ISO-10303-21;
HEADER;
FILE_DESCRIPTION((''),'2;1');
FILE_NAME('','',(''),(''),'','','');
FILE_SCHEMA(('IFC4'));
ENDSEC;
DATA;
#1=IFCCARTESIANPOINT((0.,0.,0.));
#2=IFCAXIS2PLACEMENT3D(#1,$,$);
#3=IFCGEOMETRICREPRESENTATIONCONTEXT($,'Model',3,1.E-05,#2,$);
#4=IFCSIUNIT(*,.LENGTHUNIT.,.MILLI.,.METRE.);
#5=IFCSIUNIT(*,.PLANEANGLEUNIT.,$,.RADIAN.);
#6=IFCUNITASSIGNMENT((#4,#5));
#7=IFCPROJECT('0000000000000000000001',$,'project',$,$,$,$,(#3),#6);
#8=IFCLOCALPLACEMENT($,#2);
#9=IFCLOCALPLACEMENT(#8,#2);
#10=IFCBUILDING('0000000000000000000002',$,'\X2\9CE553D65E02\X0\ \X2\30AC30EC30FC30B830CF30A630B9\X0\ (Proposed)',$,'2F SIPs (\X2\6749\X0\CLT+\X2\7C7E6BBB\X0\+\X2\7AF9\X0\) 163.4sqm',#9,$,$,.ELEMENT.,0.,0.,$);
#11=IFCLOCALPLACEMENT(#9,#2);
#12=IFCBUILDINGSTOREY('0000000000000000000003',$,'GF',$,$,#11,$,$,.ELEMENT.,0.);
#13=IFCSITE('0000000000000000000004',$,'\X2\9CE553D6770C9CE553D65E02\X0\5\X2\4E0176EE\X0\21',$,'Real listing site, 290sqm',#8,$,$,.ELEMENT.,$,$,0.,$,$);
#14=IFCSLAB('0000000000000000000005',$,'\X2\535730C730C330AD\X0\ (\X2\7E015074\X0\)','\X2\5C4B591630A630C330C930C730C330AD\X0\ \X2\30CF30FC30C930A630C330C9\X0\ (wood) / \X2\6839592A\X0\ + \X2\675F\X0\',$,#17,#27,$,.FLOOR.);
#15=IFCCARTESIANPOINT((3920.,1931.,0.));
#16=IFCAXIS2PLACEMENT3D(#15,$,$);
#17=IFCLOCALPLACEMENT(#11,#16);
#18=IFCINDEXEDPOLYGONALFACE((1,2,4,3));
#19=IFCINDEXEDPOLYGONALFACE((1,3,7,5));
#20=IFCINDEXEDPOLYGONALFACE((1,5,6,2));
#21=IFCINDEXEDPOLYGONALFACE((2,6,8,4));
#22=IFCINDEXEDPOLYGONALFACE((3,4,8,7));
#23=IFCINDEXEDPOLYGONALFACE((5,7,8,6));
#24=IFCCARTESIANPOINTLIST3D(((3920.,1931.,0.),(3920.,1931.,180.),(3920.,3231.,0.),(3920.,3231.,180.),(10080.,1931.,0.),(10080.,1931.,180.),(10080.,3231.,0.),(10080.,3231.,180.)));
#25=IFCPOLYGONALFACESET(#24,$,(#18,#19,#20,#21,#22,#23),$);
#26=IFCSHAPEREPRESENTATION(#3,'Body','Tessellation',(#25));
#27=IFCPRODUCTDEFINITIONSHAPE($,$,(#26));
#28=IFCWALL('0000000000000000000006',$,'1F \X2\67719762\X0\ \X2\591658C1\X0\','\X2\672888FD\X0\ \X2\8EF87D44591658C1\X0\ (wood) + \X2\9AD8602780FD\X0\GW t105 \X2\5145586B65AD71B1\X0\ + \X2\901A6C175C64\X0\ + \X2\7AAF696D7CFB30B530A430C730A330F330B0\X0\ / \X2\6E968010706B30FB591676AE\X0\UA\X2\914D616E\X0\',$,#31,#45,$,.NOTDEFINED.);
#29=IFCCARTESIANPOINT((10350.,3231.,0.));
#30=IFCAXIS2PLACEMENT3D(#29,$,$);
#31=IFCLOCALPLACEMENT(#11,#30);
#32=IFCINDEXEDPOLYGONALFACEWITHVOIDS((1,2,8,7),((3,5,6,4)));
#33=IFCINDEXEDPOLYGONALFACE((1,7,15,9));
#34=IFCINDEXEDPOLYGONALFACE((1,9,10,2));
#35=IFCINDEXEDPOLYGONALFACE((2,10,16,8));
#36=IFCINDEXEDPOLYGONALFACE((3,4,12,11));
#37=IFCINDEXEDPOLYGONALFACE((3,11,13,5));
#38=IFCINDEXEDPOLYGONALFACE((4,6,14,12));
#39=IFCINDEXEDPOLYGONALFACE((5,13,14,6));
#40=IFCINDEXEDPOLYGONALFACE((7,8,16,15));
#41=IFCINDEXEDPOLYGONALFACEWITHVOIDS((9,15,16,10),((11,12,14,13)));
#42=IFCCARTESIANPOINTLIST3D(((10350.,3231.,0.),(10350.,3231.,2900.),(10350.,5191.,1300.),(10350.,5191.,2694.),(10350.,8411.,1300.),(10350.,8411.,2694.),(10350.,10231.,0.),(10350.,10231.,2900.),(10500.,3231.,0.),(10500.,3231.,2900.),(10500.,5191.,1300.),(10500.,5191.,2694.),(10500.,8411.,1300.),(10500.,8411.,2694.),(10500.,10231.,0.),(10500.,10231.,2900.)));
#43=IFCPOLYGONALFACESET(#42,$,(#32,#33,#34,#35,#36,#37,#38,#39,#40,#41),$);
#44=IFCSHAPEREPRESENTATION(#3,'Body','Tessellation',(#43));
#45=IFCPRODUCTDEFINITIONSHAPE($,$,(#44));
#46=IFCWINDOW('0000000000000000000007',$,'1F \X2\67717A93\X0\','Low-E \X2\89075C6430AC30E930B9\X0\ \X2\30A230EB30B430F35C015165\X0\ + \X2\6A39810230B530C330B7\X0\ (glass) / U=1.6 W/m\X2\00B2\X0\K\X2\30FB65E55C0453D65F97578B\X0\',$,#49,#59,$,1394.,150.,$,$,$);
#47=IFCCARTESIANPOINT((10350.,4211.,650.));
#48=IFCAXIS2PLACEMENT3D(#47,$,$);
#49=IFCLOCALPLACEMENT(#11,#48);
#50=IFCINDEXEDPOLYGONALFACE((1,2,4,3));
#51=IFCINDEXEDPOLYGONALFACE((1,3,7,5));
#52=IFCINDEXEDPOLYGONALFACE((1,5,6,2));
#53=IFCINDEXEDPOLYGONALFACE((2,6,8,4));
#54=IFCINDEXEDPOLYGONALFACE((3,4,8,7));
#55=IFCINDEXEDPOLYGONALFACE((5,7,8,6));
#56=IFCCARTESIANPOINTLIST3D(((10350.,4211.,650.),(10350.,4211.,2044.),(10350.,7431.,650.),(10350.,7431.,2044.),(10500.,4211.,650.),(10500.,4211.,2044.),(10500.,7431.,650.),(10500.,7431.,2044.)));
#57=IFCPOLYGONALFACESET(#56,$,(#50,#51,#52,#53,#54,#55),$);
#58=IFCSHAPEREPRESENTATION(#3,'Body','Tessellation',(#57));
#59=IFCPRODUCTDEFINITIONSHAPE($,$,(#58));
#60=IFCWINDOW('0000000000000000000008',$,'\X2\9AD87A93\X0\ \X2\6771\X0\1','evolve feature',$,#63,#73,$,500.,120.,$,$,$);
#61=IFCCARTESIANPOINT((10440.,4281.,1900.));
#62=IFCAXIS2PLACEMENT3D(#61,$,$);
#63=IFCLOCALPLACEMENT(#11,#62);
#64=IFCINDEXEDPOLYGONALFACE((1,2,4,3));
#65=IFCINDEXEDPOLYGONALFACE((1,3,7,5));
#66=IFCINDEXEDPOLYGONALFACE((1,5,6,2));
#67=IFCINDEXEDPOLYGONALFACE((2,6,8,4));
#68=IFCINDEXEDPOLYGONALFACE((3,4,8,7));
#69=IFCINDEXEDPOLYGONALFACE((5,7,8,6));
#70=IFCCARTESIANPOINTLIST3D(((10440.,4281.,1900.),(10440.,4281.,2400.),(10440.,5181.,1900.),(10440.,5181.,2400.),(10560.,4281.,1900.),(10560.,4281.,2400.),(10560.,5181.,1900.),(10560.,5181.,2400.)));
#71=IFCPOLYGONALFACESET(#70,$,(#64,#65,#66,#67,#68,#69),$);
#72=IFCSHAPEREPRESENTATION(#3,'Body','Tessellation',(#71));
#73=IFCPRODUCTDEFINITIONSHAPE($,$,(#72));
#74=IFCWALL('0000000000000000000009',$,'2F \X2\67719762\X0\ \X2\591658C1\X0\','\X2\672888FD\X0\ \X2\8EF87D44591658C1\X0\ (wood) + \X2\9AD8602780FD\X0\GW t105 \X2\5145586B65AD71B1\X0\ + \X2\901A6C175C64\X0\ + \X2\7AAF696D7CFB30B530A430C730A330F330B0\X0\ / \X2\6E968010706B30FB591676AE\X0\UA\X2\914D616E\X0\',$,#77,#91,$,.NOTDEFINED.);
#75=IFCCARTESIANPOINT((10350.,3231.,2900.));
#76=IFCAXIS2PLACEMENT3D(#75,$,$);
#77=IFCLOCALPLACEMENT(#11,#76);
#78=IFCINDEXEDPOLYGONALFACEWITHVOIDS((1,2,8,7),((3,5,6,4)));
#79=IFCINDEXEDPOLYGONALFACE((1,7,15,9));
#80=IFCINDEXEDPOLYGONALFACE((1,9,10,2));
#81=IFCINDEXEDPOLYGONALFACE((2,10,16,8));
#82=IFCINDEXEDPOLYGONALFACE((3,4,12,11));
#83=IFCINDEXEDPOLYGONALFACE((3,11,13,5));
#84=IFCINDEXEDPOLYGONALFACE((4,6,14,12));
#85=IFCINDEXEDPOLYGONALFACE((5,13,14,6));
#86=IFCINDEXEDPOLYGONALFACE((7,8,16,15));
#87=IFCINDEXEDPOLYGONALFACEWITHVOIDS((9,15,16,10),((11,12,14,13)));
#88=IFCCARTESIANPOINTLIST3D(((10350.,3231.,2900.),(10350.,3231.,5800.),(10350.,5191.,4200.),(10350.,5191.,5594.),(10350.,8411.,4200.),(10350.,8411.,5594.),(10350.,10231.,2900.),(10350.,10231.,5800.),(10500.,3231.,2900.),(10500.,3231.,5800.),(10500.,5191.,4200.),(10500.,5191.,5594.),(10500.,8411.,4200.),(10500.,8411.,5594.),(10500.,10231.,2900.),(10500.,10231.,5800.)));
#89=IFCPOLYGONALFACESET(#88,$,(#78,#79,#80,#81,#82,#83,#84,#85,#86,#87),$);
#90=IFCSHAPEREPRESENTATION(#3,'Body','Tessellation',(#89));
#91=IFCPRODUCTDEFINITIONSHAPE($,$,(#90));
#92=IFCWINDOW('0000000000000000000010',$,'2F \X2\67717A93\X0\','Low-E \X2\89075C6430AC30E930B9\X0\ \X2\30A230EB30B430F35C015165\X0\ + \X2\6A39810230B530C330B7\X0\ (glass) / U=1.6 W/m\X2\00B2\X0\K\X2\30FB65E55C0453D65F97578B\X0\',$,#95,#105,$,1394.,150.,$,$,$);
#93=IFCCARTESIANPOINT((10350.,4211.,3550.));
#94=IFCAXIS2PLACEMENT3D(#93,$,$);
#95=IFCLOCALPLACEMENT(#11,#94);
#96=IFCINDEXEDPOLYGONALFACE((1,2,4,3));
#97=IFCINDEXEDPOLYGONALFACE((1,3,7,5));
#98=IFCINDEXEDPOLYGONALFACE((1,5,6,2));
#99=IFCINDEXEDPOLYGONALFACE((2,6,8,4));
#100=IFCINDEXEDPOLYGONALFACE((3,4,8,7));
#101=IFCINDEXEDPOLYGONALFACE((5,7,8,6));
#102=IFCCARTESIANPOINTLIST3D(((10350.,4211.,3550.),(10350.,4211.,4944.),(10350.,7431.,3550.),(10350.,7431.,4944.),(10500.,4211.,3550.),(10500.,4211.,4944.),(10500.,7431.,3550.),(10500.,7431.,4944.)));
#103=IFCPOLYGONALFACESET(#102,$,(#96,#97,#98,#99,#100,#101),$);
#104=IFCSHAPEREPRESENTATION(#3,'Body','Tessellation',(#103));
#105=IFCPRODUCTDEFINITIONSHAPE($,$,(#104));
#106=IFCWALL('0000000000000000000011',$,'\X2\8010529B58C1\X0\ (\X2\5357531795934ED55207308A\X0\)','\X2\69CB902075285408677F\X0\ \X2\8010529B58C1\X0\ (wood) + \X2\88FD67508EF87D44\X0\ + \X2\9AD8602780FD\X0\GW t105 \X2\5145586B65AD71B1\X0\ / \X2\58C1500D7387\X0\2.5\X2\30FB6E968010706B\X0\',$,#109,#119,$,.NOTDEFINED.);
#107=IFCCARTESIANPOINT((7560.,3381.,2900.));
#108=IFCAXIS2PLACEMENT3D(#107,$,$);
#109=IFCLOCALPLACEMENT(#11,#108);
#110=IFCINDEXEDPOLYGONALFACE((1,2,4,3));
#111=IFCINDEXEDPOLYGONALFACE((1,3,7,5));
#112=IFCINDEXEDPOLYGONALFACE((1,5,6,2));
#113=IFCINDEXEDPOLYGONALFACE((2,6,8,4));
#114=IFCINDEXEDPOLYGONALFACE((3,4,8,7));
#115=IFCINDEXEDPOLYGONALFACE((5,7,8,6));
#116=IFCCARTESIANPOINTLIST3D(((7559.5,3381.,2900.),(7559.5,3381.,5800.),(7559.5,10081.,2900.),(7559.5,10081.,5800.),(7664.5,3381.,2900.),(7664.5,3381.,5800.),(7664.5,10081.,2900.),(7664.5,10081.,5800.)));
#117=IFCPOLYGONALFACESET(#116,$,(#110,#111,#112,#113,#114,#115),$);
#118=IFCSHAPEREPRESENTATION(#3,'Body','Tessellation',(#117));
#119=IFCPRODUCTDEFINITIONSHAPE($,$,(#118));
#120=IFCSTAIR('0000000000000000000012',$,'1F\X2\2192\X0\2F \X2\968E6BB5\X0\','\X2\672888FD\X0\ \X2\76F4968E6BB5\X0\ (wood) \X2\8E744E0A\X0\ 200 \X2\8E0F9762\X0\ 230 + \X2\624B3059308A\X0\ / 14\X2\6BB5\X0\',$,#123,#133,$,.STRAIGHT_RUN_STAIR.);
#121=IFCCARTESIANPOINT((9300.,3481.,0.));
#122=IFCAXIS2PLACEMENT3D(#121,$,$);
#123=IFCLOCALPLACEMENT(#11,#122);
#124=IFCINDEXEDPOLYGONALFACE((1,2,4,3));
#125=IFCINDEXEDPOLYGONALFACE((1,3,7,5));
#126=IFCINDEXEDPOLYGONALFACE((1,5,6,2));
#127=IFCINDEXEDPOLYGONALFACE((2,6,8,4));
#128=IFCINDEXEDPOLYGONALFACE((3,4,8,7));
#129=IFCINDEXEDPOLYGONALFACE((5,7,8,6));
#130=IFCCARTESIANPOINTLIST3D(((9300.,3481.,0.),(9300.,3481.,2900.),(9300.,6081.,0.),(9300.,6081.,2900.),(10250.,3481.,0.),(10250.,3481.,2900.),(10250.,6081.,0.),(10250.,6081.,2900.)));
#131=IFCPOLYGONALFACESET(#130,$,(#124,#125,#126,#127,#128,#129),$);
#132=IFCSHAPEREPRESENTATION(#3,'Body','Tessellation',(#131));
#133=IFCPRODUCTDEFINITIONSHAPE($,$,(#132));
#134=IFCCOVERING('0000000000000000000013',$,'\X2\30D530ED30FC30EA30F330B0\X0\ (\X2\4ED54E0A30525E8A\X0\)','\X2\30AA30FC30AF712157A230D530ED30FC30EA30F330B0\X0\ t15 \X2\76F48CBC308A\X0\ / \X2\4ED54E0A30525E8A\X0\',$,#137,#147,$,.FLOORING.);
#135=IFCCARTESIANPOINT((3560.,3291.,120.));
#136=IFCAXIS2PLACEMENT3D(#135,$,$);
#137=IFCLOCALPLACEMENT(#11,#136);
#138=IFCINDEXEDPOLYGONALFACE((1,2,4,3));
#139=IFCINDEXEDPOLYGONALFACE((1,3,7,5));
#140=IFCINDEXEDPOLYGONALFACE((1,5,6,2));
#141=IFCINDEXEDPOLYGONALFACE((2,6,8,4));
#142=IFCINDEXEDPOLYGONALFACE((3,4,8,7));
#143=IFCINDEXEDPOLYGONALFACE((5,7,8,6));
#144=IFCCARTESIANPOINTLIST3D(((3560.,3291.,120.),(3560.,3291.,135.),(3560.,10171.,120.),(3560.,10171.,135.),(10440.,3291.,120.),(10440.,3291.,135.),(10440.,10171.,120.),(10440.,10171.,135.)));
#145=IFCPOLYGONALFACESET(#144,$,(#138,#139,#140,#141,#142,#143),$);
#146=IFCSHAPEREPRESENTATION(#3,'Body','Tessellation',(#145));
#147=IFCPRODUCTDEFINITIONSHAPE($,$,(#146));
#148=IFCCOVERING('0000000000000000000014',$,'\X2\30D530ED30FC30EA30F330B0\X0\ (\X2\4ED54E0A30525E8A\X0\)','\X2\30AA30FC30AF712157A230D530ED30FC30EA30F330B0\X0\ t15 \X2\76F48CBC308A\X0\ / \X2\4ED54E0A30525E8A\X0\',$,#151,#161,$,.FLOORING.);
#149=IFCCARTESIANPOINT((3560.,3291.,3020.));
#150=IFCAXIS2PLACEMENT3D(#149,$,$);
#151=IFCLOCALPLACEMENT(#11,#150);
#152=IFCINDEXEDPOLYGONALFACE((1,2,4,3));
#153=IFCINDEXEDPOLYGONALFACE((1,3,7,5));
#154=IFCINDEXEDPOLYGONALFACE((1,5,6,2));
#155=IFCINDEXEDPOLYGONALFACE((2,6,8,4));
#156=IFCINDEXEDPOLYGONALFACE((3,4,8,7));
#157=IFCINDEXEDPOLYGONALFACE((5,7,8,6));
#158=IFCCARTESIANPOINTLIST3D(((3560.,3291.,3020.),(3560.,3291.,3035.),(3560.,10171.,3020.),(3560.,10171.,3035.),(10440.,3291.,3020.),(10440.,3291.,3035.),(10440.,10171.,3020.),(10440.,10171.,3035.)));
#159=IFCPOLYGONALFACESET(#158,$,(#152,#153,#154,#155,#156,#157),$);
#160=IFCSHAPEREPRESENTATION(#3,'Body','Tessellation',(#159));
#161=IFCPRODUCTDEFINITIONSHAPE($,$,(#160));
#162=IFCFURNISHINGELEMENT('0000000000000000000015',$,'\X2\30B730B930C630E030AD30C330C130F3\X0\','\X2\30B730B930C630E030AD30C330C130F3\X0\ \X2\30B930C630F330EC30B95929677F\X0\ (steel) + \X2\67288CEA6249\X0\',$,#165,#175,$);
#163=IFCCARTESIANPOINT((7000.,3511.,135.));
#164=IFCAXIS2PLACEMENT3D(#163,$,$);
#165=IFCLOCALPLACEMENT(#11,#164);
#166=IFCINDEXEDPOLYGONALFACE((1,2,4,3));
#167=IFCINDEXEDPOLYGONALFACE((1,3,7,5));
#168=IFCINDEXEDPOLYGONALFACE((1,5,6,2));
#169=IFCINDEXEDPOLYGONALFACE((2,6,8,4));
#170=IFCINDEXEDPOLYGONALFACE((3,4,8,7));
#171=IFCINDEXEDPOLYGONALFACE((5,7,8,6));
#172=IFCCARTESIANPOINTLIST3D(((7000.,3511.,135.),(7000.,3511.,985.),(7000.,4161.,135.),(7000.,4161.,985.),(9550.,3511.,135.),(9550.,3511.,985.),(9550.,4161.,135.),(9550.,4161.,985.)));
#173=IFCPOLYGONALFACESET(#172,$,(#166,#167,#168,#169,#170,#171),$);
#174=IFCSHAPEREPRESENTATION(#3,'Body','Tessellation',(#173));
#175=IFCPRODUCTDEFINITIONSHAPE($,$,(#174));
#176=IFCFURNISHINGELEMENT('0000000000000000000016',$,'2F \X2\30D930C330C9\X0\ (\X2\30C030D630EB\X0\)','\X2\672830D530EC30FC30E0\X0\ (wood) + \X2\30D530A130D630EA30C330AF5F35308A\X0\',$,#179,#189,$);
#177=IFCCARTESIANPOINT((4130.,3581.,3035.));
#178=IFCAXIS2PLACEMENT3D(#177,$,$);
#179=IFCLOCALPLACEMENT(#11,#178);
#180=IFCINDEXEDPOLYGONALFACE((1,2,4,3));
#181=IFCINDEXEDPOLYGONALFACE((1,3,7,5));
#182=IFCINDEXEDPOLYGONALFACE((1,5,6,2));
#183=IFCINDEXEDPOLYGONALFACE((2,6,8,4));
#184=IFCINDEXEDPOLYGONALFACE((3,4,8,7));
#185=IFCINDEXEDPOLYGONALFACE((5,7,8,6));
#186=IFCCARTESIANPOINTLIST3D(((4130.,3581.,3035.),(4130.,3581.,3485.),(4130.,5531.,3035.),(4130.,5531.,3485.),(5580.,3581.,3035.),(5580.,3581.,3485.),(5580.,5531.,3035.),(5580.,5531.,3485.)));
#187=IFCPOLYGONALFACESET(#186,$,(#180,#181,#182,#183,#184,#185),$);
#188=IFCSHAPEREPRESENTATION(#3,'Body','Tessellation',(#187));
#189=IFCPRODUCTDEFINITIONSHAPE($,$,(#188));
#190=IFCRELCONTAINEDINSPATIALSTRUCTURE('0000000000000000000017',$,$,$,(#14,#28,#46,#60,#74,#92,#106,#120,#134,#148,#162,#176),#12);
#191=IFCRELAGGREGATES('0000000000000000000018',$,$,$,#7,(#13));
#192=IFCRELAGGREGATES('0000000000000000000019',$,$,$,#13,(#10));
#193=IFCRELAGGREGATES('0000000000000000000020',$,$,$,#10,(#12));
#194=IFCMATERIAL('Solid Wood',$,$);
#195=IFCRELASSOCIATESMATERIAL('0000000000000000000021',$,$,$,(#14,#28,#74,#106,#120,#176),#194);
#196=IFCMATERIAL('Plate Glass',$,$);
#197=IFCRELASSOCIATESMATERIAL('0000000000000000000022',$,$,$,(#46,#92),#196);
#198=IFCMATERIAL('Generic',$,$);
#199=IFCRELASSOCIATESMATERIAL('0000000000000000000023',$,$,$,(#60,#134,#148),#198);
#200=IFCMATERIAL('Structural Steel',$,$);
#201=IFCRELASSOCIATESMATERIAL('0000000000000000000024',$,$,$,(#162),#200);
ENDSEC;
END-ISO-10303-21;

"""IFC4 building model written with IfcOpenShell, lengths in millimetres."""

from ifc_helpers import new_model, si_unit, frame, frame_2d, origin, place, context, project, spatial, rectangle, extrude, material, element, fill, save


model = new_model("IFC4")

# Units and contexts
model_context = context("Model", 3, precision=1e-05, world=origin())
ifc_project = project(units=[si_unit("LENGTHUNIT", "METRE", prefix="MILLI"), si_unit("PLANEANGLEUNIT", "RADIAN")], contexts=[model_context])

# Site, building, storey
site_placement = place(None, origin())
site = spatial("IfcSite", under=ifc_project, at=site_placement, Name="鳥取県鳥取市5丁目21", ObjectType="Real listing site, 290sqm", CompositionType="ELEMENT", RefElevation=0.0)
building_placement = place(site_placement, origin())
building = spatial("IfcBuilding", under=site, at=building_placement, Name="鳥取市 ガレージハウス (Proposed)", ObjectType="2F SIPs (杉CLT+籾殻+竹) 163.4sqm", CompositionType="ELEMENT", ElevationOfRefHeight=0.0, ElevationOfTerrain=0.0)
storey_placement = place(building_placement, origin())
storey = spatial("IfcBuildingStorey", under=building, at=storey_placement, Name="GF", CompositionType="ELEMENT", Elevation=0.0)

# Slab
ifc_material_1 = material(Name="Solid Wood")
slab_placement = place(storey_placement, frame((3920.0, 1931.0, 0.0)))
element("IfcSlab", 1, at=slab_placement, inside=storey, material=ifc_material_1, Name="南デッキ (縁側)", Description="屋外ウッドデッキ ハードウッド (wood) / 根太 + 束", PredefinedType="FLOOR", context=model_context, shape_type="SweptSolid", body=[
    extrude(rectangle(XDim=6160.0, YDim=1300.0, at=frame_2d((3080.0, 650.0))), frame((3920.0, 1931.0, 0.0)), (0.0, 0.0, 1.0), 180.0),
])

# Wall, openings, windows
wall_1_placement = place(storey_placement, frame((10350.0, 3231.0, 0.0)))
wall_1 = element("IfcWall", 2, at=wall_1_placement, inside=storey, material=ifc_material_1, Name="1F 東面 外壁", Description="木製 軸組外壁 (wood) + 高性能GW t105 充填断熱 + 通気層 + 窯業系サイディング / 準耐火・外皮UA配慮", PredefinedType="NOTDEFINED", context=model_context, shape_type="SweptSolid", body=[
    extrude(rectangle(XDim=150.0, YDim=7000.0, at=frame_2d((75.0, 3500.0))), frame((10350.0, 3231.0, 0.0)), (0.0, 0.0, 1.0), 2900.0),
])
opening_1_placement = place(storey_placement, frame((10350.0, 4211.0, 650.0)))
opening_1 = element("IfcOpeningElement", 3, at=opening_1_placement, cuts=wall_1, PredefinedType="NOTDEFINED", context=model_context, shape_type="SweptSolid", body=[
    extrude(rectangle(XDim=150.0, YDim=3220.0, at=frame_2d((75.0, 1610.0))), frame((10350.0, 4211.0, 650.0)), (0.0, 0.0, 1.0), 1394.0),
])
opening_2_placement = place(storey_placement, frame((10440.0, 4281.0, 1900.0)))
opening_2 = element("IfcOpeningElement", 4, at=opening_2_placement, cuts=wall_1, PredefinedType="NOTDEFINED", context=model_context, shape_type="SweptSolid", body=[
    extrude(rectangle(XDim=120.0, YDim=900.0, at=frame_2d((60.0, 450.0))), frame((10440.0, 4281.0, 1900.0)), (0.0, 0.0, 1.0), 500.0),
])
ifc_material_2 = material(Name="Plate Glass")
window_1_placement = place(storey_placement, frame((10350.0, 4211.0, 650.0)))
window_1 = element("IfcWindow", 5, at=window_1_placement, inside=storey, material=ifc_material_2, Name="1F 東窓", Description="Low-E 複層ガラス アルゴン封入 + 樹脂サッシ (glass) / U=1.6 W/m²K・日射取得型", OverallHeight=1394.0, OverallWidth=150.0, context=model_context, shape_type="SweptSolid", body=[
    extrude(rectangle(XDim=150.0, YDim=3220.0, at=frame_2d((75.0, 1610.0))), frame((10350.0, 4211.0, 650.0)), (0.0, 0.0, 1.0), 1394.0),
])
fill(opening_1, window_1)
ifc_material_3 = material(Name="Generic")
window_2_placement = place(storey_placement, frame((10440.0, 4281.0, 1900.0)))
window_2 = element("IfcWindow", 6, at=window_2_placement, inside=storey, material=ifc_material_3, Name="高窓 東1", Description="evolve feature", OverallHeight=500.0, OverallWidth=120.0, context=model_context, shape_type="SweptSolid", body=[
    extrude(rectangle(XDim=120.0, YDim=900.0, at=frame_2d((60.0, 450.0))), frame((10440.0, 4281.0, 1900.0)), (0.0, 0.0, 1.0), 500.0),
])
fill(opening_2, window_2)

# Wall, opening, window
wall_2_placement = place(storey_placement, frame((10350.0, 3231.0, 2900.0)))
wall_2 = element("IfcWall", 7, at=wall_2_placement, inside=storey, material=ifc_material_1, Name="2F 東面 外壁", Description="木製 軸組外壁 (wood) + 高性能GW t105 充填断熱 + 通気層 + 窯業系サイディング / 準耐火・外皮UA配慮", PredefinedType="NOTDEFINED", context=model_context, shape_type="SweptSolid", body=[
    extrude(rectangle(XDim=150.0, YDim=7000.0, at=frame_2d((75.0, 3500.0))), frame((10350.0, 3231.0, 2900.0)), (0.0, 0.0, 1.0), 2900.0),
])
opening_3_placement = place(storey_placement, frame((10350.0, 4211.0, 3550.0)))
opening_3 = element("IfcOpeningElement", 8, at=opening_3_placement, cuts=wall_2, PredefinedType="NOTDEFINED", context=model_context, shape_type="SweptSolid", body=[
    extrude(rectangle(XDim=150.0, YDim=3220.0, at=frame_2d((75.0, 1610.0))), frame((10350.0, 4211.0, 3550.0)), (0.0, 0.0, 1.0), 1394.0),
])
window_3_placement = place(storey_placement, frame((10350.0, 4211.0, 3550.0)))
window_3 = element("IfcWindow", 9, at=window_3_placement, inside=storey, material=ifc_material_2, Name="2F 東窓", Description="Low-E 複層ガラス アルゴン封入 + 樹脂サッシ (glass) / U=1.6 W/m²K・日射取得型", OverallHeight=1394.0, OverallWidth=150.0, context=model_context, shape_type="SweptSolid", body=[
    extrude(rectangle(XDim=150.0, YDim=3220.0, at=frame_2d((75.0, 1610.0))), frame((10350.0, 4211.0, 3550.0)), (0.0, 0.0, 1.0), 1394.0),
])
fill(opening_3, window_3)

# Wall
wall_3_placement = place(storey_placement, frame((7560.0, 3381.0, 2900.0)))
element("IfcWall", 10, at=wall_3_placement, inside=storey, material=ifc_material_1, Name="耐力壁 (南北間仕切り)", Description="構造用合板 耐力壁 (wood) + 製材軸組 + 高性能GW t105 充填断熱 / 壁倍率2.5・準耐火", PredefinedType="NOTDEFINED", context=model_context, shape_type="SweptSolid", body=[
    extrude(rectangle(XDim=105.0, YDim=6700.0, at=frame_2d((52.0, 3350.0))), frame((7560.0, 3381.0, 2900.0)), (0.0, 0.0, 1.0), 2900.0),
])

# Stair
stair_placement = place(storey_placement, frame((9300.0, 3481.0, 0.0)))
element("IfcStair", 11, at=stair_placement, inside=storey, material=ifc_material_1, Name="1F→2F 階段", Description="木製 直階段 (wood) 蹴上 200 踏面 230 + 手すり / 14段", PredefinedType="STRAIGHT_RUN_STAIR", context=model_context, shape_type="SweptSolid", body=[
    extrude(rectangle(XDim=950.0, YDim=2600.0, at=frame_2d((475.0, 1300.0))), frame((9300.0, 3481.0, 0.0)), (0.0, 0.0, 1.0), 2900.0),
])

# Coverings
covering_1_placement = place(storey_placement, frame((3560.0, 3291.0, 120.0)))
element("IfcCovering", 12, at=covering_1_placement, inside=storey, material=ifc_material_3, Name="フローリング (仕上げ床)", Description="オーク無垢フローリング t15 直貼り / 仕上げ床", PredefinedType="FLOORING", context=model_context, shape_type="SweptSolid", body=[
    extrude(rectangle(XDim=6880.0, YDim=6880.0, at=frame_2d((3440.0, 3440.0))), frame((3560.0, 3291.0, 120.0)), (0.0, 0.0, 1.0), 15.0),
])
covering_2_placement = place(storey_placement, frame((3560.0, 3291.0, 3020.0)))
element("IfcCovering", 13, at=covering_2_placement, inside=storey, material=ifc_material_3, Name="フローリング (仕上げ床)", Description="オーク無垢フローリング t15 直貼り / 仕上げ床", PredefinedType="FLOORING", context=model_context, shape_type="SweptSolid", body=[
    extrude(rectangle(XDim=6880.0, YDim=6880.0, at=frame_2d((3440.0, 3440.0))), frame((3560.0, 3291.0, 3020.0)), (0.0, 0.0, 1.0), 15.0),
])

# Furnishing elements
ifc_material_4 = material(Name="Structural Steel")
furnishing_1_placement = place(storey_placement, frame((7000.0, 3511.0, 135.0)))
element("IfcFurnishingElement", 14, at=furnishing_1_placement, inside=storey, material=ifc_material_4, Name="システムキッチン", Description="システムキッチン ステンレス天板 (steel) + 木質扉", context=model_context, shape_type="SweptSolid", body=[
    extrude(rectangle(XDim=2550.0, YDim=650.0, at=frame_2d((1275.0, 325.0))), frame((7000.0, 3511.0, 135.0)), (0.0, 0.0, 1.0), 850.0),
])
furnishing_2_placement = place(storey_placement, frame((4130.0, 3581.0, 3035.0)))
element("IfcFurnishingElement", 15, at=furnishing_2_placement, inside=storey, material=ifc_material_1, Name="2F ベッド (ダブル)", Description="木フレーム (wood) + ファブリック張り", context=model_context, shape_type="SweptSolid", body=[
    extrude(rectangle(XDim=1450.0, YDim=1950.0, at=frame_2d((725.0, 975.0))), frame((4130.0, 3581.0, 3035.0)), (0.0, 0.0, 1.0), 450.0),
])

save(model, "model.ifc")
